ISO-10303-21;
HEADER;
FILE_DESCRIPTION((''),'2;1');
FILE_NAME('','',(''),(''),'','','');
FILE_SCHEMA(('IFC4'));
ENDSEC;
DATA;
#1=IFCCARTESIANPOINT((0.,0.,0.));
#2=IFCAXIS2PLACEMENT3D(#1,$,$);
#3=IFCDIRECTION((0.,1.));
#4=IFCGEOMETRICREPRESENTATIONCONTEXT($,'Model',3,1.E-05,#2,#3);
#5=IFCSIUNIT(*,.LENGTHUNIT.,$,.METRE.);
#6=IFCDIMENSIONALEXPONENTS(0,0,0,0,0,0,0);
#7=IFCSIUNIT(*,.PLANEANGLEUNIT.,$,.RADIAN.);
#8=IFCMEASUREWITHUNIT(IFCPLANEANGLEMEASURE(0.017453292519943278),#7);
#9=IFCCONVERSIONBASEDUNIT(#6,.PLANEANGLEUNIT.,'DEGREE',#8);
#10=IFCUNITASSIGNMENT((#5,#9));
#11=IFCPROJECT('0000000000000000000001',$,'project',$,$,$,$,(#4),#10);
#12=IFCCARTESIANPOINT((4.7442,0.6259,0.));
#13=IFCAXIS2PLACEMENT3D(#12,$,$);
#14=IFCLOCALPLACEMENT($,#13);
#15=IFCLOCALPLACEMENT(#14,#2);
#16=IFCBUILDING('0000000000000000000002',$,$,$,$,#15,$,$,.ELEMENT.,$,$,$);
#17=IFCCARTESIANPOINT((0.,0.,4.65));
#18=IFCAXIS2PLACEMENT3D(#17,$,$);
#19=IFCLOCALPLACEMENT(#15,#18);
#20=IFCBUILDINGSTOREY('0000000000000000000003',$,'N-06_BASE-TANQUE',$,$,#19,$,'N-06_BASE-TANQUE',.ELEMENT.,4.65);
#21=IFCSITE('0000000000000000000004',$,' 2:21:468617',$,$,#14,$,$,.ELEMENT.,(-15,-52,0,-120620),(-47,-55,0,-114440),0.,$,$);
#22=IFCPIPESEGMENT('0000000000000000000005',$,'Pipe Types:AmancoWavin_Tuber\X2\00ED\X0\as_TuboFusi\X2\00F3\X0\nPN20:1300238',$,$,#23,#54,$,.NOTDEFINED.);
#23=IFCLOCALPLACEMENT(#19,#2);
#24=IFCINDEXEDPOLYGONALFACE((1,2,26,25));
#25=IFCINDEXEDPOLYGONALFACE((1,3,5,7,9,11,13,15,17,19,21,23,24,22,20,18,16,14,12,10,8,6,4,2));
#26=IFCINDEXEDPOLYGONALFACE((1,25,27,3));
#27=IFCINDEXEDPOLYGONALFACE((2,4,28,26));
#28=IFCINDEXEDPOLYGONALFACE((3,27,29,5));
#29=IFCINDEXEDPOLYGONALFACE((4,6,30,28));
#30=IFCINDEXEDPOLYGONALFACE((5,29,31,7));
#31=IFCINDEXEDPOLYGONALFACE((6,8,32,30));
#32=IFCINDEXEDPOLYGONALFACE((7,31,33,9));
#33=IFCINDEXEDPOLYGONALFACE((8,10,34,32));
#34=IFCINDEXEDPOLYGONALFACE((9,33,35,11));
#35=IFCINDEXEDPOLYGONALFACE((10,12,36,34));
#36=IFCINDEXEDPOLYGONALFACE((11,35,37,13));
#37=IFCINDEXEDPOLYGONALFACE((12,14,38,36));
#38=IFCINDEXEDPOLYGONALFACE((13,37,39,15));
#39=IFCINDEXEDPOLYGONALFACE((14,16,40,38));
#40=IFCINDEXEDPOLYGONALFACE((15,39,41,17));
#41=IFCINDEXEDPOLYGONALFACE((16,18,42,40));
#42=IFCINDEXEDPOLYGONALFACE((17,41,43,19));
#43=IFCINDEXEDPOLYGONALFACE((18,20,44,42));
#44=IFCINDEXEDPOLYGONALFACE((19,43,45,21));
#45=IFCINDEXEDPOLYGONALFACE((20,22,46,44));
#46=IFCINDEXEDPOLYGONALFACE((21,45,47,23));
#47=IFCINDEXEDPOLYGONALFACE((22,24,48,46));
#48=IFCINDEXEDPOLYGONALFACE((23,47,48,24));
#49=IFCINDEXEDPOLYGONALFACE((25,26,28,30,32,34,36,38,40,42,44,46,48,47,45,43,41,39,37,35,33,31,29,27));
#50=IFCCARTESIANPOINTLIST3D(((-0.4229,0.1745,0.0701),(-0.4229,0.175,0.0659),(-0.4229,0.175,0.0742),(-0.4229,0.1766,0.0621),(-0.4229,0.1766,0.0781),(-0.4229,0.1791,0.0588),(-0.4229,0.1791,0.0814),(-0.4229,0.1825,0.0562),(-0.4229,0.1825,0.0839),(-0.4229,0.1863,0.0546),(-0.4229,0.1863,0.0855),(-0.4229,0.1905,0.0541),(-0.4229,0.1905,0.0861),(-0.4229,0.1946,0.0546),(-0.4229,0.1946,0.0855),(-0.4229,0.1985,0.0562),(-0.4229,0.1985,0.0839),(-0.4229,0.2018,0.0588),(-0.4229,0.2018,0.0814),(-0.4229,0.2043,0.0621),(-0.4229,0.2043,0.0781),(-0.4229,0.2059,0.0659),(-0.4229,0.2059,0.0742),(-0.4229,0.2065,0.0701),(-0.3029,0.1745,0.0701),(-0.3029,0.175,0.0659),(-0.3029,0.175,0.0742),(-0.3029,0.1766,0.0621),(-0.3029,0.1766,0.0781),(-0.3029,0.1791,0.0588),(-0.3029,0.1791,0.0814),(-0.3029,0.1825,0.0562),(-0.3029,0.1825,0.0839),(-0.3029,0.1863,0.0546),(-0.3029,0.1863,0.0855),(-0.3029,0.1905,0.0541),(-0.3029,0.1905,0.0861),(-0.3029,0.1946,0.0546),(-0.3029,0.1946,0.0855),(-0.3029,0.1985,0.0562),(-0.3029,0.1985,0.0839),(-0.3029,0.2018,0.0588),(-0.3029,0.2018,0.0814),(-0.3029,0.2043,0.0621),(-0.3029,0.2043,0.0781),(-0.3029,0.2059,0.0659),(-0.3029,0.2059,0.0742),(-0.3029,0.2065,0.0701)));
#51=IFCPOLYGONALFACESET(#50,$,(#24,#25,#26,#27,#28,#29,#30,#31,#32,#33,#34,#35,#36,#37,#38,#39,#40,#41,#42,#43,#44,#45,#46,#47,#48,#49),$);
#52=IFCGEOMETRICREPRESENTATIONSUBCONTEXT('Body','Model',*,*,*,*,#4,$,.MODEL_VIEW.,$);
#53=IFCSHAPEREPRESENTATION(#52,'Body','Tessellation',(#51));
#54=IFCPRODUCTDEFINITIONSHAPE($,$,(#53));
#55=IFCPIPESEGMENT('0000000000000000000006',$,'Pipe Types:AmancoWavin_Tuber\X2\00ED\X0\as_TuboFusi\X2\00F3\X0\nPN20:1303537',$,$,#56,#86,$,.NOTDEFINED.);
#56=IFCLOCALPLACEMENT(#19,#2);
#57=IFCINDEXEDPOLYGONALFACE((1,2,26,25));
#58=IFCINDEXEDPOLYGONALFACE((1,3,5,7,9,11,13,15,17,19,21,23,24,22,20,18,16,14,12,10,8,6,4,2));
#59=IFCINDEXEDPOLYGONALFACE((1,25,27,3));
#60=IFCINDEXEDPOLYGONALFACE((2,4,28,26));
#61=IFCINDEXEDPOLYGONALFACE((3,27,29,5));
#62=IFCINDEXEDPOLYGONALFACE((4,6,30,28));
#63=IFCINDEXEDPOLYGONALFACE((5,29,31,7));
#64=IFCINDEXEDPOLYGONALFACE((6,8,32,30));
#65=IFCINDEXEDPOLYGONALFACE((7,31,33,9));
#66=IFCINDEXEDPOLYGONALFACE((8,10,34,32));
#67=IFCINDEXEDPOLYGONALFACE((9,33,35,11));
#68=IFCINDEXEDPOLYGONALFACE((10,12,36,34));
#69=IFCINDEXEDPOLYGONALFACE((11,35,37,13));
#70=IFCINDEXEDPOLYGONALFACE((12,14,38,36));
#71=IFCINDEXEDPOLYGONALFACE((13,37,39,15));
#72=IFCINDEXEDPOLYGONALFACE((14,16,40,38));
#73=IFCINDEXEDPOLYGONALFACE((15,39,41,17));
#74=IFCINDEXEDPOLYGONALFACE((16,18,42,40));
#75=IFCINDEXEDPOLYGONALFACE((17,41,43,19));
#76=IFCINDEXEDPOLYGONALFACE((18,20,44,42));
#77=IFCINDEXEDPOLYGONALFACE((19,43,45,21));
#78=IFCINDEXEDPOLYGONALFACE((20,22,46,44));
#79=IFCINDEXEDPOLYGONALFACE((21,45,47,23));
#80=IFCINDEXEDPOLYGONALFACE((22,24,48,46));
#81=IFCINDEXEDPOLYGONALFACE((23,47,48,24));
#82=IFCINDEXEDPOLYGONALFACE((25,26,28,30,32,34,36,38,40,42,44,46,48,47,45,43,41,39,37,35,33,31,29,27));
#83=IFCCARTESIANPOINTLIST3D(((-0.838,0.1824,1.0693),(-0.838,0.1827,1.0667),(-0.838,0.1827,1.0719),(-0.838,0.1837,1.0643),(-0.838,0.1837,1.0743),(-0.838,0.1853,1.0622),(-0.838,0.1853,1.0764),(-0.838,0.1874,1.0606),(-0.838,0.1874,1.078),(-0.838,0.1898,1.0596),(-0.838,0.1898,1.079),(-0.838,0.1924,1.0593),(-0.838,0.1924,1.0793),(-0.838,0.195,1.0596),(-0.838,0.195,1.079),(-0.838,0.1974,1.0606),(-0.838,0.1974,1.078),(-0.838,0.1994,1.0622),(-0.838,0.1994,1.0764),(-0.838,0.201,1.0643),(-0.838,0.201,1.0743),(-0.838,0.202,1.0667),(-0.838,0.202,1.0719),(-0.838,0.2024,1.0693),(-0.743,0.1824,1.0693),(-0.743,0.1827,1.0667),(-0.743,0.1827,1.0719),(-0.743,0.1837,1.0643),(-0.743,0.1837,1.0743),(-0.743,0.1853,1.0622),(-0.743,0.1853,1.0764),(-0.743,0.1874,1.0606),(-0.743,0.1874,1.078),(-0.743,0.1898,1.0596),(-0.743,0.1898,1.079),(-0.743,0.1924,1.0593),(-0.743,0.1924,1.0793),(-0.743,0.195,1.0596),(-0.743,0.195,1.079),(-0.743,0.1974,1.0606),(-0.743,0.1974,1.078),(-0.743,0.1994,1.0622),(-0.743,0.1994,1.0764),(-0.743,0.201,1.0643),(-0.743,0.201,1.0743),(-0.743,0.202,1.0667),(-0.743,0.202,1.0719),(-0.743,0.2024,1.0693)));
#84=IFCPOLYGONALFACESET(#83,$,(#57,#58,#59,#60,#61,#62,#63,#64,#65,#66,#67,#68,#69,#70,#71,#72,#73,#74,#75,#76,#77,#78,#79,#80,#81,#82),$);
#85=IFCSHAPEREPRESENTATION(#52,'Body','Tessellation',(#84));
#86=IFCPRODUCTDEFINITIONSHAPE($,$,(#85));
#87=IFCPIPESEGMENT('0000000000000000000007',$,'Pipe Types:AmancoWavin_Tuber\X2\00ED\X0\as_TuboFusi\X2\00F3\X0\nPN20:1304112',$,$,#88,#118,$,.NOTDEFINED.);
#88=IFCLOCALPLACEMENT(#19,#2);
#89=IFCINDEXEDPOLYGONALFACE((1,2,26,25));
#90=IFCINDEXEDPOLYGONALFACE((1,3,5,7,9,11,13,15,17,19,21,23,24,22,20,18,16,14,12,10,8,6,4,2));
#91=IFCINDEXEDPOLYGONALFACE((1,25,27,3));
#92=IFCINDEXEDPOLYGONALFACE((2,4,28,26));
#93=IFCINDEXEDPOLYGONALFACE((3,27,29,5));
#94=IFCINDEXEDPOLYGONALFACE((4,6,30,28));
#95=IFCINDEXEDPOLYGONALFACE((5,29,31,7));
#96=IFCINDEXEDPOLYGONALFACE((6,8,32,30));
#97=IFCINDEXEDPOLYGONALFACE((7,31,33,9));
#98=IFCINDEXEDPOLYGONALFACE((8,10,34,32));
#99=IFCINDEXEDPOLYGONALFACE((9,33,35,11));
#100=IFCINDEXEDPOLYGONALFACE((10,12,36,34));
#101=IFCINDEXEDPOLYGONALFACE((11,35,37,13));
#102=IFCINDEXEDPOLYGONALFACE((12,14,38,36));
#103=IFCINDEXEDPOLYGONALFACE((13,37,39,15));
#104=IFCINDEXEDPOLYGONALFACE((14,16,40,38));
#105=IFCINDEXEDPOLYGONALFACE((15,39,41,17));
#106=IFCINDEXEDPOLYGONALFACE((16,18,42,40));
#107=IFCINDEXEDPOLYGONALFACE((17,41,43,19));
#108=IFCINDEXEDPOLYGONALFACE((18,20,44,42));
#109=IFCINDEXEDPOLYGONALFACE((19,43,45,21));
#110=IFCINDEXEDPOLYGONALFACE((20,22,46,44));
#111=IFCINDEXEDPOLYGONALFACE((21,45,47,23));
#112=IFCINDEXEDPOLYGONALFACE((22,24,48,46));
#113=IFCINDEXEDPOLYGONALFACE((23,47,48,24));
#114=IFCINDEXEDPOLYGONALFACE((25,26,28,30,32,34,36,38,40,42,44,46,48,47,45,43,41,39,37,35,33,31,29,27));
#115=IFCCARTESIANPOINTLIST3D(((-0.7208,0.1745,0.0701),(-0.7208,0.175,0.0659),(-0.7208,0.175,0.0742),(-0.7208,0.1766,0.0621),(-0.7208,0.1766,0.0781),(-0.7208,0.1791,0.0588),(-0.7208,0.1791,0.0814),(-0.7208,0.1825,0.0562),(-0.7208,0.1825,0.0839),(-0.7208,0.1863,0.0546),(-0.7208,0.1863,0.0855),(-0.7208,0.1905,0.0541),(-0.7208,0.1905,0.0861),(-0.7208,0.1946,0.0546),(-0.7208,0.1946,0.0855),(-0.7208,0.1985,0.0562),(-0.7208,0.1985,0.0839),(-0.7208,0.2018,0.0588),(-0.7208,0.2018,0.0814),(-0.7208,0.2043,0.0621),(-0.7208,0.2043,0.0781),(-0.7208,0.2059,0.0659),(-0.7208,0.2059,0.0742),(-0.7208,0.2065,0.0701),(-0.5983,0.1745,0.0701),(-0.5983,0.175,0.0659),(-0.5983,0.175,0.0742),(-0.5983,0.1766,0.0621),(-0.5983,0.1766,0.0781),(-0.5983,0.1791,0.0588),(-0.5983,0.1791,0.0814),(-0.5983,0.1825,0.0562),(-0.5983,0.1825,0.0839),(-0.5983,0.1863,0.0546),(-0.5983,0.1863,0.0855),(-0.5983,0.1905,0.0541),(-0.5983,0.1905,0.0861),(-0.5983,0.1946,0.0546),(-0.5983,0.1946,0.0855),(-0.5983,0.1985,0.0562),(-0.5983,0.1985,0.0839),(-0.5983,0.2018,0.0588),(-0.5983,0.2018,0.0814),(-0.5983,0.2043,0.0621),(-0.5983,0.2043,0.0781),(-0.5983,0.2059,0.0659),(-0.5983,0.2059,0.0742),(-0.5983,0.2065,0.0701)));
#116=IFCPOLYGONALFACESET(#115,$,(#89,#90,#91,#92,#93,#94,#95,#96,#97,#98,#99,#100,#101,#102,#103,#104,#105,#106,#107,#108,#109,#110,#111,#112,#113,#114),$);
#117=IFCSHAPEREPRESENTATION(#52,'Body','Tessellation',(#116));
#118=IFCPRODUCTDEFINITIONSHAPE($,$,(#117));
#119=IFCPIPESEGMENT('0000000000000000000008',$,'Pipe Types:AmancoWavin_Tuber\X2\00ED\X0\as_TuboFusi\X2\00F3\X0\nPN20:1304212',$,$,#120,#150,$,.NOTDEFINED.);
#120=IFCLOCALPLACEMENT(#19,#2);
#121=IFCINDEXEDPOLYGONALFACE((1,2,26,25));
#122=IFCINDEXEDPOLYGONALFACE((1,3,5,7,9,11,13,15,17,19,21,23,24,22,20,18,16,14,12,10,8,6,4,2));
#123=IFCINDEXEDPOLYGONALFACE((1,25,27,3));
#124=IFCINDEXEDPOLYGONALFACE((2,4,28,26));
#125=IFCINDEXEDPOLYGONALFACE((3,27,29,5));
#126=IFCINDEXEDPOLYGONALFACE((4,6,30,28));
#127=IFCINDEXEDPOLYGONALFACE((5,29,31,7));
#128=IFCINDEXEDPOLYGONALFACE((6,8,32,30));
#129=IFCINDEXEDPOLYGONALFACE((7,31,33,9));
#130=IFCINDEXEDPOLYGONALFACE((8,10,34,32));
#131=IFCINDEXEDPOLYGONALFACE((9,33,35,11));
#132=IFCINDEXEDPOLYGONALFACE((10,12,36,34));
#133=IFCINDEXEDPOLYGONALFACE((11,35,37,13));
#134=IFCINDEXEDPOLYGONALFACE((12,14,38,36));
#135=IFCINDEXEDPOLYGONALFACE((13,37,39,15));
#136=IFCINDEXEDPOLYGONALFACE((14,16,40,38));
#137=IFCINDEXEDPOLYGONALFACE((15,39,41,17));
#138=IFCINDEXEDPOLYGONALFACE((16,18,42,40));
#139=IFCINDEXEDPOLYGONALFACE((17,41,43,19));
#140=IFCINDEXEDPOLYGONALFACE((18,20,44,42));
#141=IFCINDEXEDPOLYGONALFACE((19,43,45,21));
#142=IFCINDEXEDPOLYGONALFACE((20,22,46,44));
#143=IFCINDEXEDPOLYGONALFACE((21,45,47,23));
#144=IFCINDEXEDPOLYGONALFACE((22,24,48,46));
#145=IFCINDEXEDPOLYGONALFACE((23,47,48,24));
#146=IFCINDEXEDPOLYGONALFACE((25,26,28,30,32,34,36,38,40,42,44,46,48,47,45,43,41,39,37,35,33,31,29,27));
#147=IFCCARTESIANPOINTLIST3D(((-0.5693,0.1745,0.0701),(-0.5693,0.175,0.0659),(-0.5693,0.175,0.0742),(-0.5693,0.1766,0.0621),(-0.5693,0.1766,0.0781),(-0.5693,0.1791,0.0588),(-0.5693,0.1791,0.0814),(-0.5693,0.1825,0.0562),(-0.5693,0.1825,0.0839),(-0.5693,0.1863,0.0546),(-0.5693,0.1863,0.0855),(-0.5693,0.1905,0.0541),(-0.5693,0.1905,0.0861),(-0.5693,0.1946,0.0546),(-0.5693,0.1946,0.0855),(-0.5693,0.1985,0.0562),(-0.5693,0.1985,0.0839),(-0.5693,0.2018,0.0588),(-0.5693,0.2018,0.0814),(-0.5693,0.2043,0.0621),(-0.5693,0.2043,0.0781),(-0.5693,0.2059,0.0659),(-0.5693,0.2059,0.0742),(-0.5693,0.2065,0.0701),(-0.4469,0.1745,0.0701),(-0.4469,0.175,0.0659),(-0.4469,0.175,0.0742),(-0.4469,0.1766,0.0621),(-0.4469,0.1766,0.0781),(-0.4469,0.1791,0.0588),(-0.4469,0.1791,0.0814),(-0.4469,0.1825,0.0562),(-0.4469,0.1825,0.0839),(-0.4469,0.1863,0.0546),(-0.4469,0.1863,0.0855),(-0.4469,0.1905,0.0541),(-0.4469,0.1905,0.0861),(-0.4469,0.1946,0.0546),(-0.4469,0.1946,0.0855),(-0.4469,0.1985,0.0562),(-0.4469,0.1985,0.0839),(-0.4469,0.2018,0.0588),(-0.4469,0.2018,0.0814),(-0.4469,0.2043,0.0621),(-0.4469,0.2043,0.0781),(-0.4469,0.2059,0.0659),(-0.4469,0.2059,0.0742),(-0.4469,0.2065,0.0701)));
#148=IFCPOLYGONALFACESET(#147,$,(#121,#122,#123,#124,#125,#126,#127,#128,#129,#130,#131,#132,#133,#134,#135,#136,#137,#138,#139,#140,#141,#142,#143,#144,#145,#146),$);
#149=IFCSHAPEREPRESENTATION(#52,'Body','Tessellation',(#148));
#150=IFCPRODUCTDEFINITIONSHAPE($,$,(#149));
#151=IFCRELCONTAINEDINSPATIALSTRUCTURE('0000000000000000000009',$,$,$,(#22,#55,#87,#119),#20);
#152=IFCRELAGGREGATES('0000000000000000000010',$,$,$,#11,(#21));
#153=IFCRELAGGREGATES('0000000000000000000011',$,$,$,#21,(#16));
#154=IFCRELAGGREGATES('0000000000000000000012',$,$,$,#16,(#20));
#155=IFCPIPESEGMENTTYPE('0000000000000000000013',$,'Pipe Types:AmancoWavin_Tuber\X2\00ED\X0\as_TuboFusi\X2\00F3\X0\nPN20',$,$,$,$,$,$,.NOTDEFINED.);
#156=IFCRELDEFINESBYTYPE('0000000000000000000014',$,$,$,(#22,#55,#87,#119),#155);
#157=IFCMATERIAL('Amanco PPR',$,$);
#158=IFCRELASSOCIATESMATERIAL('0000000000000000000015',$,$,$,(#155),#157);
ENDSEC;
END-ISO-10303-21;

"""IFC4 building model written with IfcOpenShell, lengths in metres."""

from ifc_helpers import new_model, entity, si_unit, converted_unit, direction, frame, origin, place, context, subcontext, project, spatial, arc, indexed_curve, outline, extrude, material, type_object, element, save


model = new_model("IFC4")

# Units and contexts
model_context = context("Model", 3, precision=1e-05, world=origin(), true_north=direction((0.0, 1.0)))
body_context = subcontext(model_context, "Body", "Model", "MODEL_VIEW")
ifc_project = project(units=[si_unit("LENGTHUNIT", "METRE"), converted_unit("PLANEANGLEUNIT", "DEGREE", entity("IfcPlaneAngleMeasure", 0.017453292519943278), si_unit("PLANEANGLEUNIT", "RADIAN"), dimensions=[0, 0, 0, 0, 0, 0, 0])], contexts=[model_context])

# Site, building, storey
site_placement = place(None, frame((4.7442, 0.6259, 0.0)))
site = spatial("IfcSite", under=ifc_project, at=site_placement, Name=" 2:21:468617", CompositionType="ELEMENT", RefLatitude=(-15, -52, 0, -120620), RefLongitude=(-47, -55, 0, -114440), RefElevation=0.0)
building_placement = place(site_placement, origin())
building = spatial("IfcBuilding", under=site, at=building_placement, CompositionType="ELEMENT")
storey_placement = place(building_placement, frame((0.0, 0.0, 4.65)))
storey = spatial("IfcBuildingStorey", under=building, at=storey_placement, Name="N-06_BASE-TANQUE", LongName="N-06_BASE-TANQUE", CompositionType="ELEMENT", Elevation=4.65)

# Pipe segments
ifc_material = material(Name="Amanco PPR")
pipe_segment_type = type_object("IfcPipeSegmentType", Name="Pipe Types:AmancoWavin_Tuberías_TuboFusiónPN20", PredefinedType="NOTDEFINED", material=ifc_material)
pipe_segment_1_placement = place(storey_placement, origin())
element("IfcPipeSegment", 1, at=pipe_segment_1_placement, inside=storey, type_object=pipe_segment_type, Name="Pipe Types:AmancoWavin_Tuberías_TuboFusiónPN20:1300238", PredefinedType="NOTDEFINED", context=body_context, shape_type="SweptSolid", body=[
    extrude(outline(indexed_curve([(0.016, 0.0), (0.0113, 0.0113), (0.0, 0.016), (-0.0113, 0.0113), (-0.016, 0.0), (-0.0113, -0.0113), (0.0, -0.016), (0.0113, -0.0113)], segments=[arc(1, 2, 3), arc(3, 4, 5), arc(5, 6, 7), arc(7, 8, 1)], self_intersect=False)), frame((-0.4229, 0.1905, 0.0701), z_axis=(1.0, 0.0, 0.0), x_axis=(0.0, -1.0, 0.0)), (0.0, 0.0, 1.0), 0.12),
])
pipe_segment_2_placement = place(storey_placement, origin())
element("IfcPipeSegment", 2, at=pipe_segment_2_placement, inside=storey, type_object=pipe_segment_type, Name="Pipe Types:AmancoWavin_Tuberías_TuboFusiónPN20:1303537", PredefinedType="NOTDEFINED", context=body_context, shape_type="SweptSolid", body=[
    extrude(outline(indexed_curve([(0.01, 0.0), (0.0071, 0.0071), (0.0, 0.01), (-0.0071, 0.0071), (-0.01, 0.0), (-0.0071, -0.0071), (0.0, -0.01), (0.0071, -0.0071)], segments=[arc(1, 2, 3), arc(3, 4, 5), arc(5, 6, 7), arc(7, 8, 1)], self_intersect=False)), frame((-0.838, 0.1924, 1.0693), z_axis=(1.0, 0.0, 0.0), x_axis=(0.0, -1.0, 0.0)), (0.0, 0.0, 1.0), 0.095),
])
pipe_segment_3_placement = place(storey_placement, origin())
element("IfcPipeSegment", 3, at=pipe_segment_3_placement, inside=storey, type_object=pipe_segment_type, Name="Pipe Types:AmancoWavin_Tuberías_TuboFusiónPN20:1304112", PredefinedType="NOTDEFINED", context=body_context, shape_type="SweptSolid", body=[
    extrude(outline(indexed_curve([(0.016, 0.0), (0.0113, 0.0113), (0.0, 0.016), (-0.0113, 0.0113), (-0.016, 0.0), (-0.0113, -0.0113), (0.0, -0.016), (0.0113, -0.0113)], segments=[arc(1, 2, 3), arc(3, 4, 5), arc(5, 6, 7), arc(7, 8, 1)], self_intersect=False)), frame((-0.7208, 0.1905, 0.0701), z_axis=(1.0, 0.0, 0.0), x_axis=(0.0, 1.0, 0.0)), (0.0, 0.0, 1.0), 0.1225),
])
pipe_segment_4_placement = place(storey_placement, origin())
element("IfcPipeSegment", 4, at=pipe_segment_4_placement, inside=storey, type_object=pipe_segment_type, Name="Pipe Types:AmancoWavin_Tuberías_TuboFusiónPN20:1304212", PredefinedType="NOTDEFINED", context=body_context, shape_type="SweptSolid", body=[
    extrude(outline(indexed_curve([(0.016, 0.0), (0.0113, 0.0113), (0.0, 0.016), (-0.0113, 0.0113), (-0.016, 0.0), (-0.0113, -0.0113), (0.0, -0.016), (0.0113, -0.0113)], segments=[arc(1, 2, 3), arc(3, 4, 5), arc(5, 6, 7), arc(7, 8, 1)], self_intersect=False)), frame((-0.5693, 0.1905, 0.0701), z_axis=(1.0, 0.0, 0.0), x_axis=(0.0, 1.0, 0.0)), (0.0, 0.0, 1.0), 0.1225),
])

save(model, "model.ifc")
